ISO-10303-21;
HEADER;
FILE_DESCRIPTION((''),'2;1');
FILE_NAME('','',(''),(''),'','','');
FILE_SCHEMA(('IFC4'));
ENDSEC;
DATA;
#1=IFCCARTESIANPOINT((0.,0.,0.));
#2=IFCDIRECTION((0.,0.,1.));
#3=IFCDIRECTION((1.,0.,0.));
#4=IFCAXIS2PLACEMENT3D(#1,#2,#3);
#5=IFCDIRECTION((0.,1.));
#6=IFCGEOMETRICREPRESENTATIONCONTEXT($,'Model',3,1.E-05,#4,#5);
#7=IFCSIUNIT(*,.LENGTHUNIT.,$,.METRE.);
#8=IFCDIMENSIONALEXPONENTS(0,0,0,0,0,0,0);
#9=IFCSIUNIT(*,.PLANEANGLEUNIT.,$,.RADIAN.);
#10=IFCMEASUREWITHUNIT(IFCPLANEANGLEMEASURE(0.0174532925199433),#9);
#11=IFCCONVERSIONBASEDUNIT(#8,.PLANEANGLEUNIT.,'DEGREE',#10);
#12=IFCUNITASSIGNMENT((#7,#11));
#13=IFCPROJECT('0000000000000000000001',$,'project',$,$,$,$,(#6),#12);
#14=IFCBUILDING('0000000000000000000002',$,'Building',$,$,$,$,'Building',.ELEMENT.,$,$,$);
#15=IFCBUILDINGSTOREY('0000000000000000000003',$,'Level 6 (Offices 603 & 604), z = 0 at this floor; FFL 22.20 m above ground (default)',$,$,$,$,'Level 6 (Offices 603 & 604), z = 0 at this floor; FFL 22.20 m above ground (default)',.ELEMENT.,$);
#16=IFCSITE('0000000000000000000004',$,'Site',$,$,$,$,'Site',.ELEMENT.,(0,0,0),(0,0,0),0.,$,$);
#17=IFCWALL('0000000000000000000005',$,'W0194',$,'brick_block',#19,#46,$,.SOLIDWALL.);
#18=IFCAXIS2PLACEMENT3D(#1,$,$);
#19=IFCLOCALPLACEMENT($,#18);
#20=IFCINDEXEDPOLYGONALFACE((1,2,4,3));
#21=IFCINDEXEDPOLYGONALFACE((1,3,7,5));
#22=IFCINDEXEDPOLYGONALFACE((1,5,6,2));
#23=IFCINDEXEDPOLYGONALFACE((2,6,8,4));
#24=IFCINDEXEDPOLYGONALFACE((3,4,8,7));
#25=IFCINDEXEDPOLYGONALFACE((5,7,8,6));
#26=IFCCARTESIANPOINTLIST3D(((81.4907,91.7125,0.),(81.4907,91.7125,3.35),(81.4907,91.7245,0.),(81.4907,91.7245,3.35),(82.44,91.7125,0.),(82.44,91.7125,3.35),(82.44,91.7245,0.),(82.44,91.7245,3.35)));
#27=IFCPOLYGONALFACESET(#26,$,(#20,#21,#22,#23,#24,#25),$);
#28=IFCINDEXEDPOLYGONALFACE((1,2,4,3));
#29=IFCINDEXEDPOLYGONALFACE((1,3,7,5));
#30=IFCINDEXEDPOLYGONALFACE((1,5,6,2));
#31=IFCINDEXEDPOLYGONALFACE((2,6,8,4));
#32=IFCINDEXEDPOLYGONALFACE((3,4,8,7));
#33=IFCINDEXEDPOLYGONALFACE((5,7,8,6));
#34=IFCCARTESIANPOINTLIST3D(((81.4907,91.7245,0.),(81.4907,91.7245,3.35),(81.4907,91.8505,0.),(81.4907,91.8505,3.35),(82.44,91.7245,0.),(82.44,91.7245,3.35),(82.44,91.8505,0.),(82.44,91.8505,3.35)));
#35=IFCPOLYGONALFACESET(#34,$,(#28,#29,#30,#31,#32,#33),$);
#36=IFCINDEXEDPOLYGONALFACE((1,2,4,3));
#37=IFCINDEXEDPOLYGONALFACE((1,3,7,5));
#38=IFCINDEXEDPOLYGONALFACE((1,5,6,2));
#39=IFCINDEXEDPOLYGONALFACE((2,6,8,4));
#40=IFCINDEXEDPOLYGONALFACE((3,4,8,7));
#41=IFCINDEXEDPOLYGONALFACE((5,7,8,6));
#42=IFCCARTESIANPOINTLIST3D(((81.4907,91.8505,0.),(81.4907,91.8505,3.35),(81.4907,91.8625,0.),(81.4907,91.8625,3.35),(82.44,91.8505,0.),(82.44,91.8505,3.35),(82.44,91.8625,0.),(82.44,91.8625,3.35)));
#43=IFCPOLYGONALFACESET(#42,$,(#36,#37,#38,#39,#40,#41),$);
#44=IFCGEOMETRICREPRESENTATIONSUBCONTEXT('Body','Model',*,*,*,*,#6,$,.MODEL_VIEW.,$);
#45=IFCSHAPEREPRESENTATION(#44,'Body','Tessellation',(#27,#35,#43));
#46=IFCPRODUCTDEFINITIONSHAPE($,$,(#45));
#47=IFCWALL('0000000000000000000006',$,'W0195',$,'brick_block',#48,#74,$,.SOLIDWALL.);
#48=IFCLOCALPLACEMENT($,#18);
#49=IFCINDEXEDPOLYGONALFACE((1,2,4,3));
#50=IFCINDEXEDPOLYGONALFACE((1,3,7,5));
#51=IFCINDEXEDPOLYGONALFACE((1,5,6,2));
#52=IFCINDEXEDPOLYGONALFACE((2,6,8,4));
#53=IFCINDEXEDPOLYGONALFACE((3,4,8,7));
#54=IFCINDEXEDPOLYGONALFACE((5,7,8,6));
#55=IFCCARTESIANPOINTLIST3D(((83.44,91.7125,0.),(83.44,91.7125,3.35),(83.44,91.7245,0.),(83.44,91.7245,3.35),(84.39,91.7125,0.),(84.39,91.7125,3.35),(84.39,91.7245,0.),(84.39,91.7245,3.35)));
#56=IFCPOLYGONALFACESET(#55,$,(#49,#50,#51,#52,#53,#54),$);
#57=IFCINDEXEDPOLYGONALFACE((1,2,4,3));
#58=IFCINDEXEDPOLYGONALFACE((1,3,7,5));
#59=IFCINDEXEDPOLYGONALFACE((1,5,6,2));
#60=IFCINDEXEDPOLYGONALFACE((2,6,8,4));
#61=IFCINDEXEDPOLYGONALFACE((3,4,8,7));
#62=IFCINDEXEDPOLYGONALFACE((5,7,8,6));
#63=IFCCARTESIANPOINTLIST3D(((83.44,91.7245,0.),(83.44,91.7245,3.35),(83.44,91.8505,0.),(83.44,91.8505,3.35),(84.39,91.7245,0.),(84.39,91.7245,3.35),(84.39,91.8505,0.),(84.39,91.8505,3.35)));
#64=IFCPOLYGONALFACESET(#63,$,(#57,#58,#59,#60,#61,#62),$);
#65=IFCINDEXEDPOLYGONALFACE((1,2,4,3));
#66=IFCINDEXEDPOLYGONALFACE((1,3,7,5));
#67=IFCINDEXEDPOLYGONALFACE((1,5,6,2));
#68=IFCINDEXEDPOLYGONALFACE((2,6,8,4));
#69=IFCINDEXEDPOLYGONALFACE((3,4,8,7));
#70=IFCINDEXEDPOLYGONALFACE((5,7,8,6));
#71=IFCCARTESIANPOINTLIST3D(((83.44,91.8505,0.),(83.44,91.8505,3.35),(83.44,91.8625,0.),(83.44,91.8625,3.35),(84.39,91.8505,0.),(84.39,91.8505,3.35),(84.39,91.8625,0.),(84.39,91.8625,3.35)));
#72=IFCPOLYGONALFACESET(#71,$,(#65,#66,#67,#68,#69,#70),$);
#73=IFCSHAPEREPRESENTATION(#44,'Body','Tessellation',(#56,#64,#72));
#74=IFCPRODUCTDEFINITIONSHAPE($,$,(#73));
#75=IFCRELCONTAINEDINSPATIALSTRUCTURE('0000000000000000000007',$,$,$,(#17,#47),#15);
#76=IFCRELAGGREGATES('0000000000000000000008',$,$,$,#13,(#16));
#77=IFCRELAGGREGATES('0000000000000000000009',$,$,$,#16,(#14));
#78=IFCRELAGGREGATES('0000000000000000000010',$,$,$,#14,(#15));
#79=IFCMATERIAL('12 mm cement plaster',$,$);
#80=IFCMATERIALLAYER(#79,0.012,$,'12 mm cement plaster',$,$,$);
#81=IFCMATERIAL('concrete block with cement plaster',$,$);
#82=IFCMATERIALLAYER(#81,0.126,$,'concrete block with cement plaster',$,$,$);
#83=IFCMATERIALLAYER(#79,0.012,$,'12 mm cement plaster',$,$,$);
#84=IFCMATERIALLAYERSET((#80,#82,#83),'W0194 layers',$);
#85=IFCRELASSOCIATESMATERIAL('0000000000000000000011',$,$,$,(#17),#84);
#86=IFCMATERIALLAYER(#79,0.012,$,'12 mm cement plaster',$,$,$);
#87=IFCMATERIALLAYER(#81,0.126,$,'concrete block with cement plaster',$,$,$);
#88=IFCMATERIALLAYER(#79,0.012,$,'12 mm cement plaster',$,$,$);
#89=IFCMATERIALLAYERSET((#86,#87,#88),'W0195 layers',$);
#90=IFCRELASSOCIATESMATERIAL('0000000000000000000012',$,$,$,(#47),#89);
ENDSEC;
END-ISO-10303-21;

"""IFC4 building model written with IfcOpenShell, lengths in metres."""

from ifc_helpers import new_model, entity, si_unit, converted_unit, direction, frame, frame_2d, origin_with_axes, origin_2d_with_axis, place, context, subcontext, project, spatial, rectangle, extrude, material, layer, layer_set, layer_usage, element, save


model = new_model("IFC4")

# Units and contexts
model_context = context("Model", 3, precision=1e-05, world=origin_with_axes(), true_north=direction((0.0, 1.0)))
body_context = subcontext(model_context, "Body", "Model", "MODEL_VIEW")
ifc_project = project(units=[si_unit("LENGTHUNIT", "METRE"), converted_unit("PLANEANGLEUNIT", "DEGREE", entity("IfcPlaneAngleMeasure", 0.0174532925199433), si_unit("PLANEANGLEUNIT", "RADIAN"), dimensions=[0, 0, 0, 0, 0, 0, 0])], contexts=[model_context])

# Site, building, storey
site = spatial("IfcSite", under=ifc_project, Name="Site", LongName="Site", CompositionType="ELEMENT", RefLatitude=(0, 0, 0), RefLongitude=(0, 0, 0), RefElevation=0.0)
building = spatial("IfcBuilding", under=site, Name="Building", LongName="Building", CompositionType="ELEMENT")
storey = spatial("IfcBuildingStorey", under=building, Name="Level 6 (Offices 603 & 604), z = 0 at this floor; FFL 22.20 m above ground (default)", LongName="Level 6 (Offices 603 & 604), z = 0 at this floor; FFL 22.20 m above ground (default)", CompositionType="ELEMENT")

# Shared definitions
placement = place(None, origin_with_axes())

# Walls
ifc_material_1 = material(Name="12 mm cement plaster")
ifc_material_2 = material(Name="concrete block with cement plaster")
ifc_layer_1 = layer(ifc_material_1, 0.012, Name="12 mm cement plaster")
ifc_layer_2 = layer(ifc_material_2, 0.126, Name="concrete block with cement plaster")
ifc_layer_3 = layer(ifc_material_1, 0.012, Name="12 mm cement plaster")
ifc_layer_set_1 = layer_set([ifc_layer_1, ifc_layer_2, ifc_layer_3], Name="W0194 layers")
ifc_layer_usage_1 = layer_usage(ifc_layer_set_1, "AXIS2", "POSITIVE", -0.075)
element("IfcWall", 1, at=placement, inside=storey, material=ifc_layer_usage_1, Name="W0194", ObjectType="brick_block", PredefinedType="SOLIDWALL", context=body_context, shape_type="SweptSolid", body=[
    extrude(rectangle(XDim=0.9493, YDim=0.012, at=origin_2d_with_axis()), frame((81.9654, 91.7185, 0.0), z_axis=(0.0, 0.0, 1.0), x_axis=(1.0, 0.0, 0.0)), (0.0, 0.0, 1.0), 3.35),
    extrude(rectangle(XDim=0.9493, YDim=0.126, at=frame_2d((0.0, 0.069), x_axis=(1.0, 0.0))), frame((81.9654, 91.7185, 0.0), z_axis=(0.0, 0.0, 1.0), x_axis=(1.0, 0.0, 0.0)), (0.0, 0.0, 1.0), 3.35),
    extrude(rectangle(XDim=0.9493, YDim=0.012, at=frame_2d((0.0, 0.138), x_axis=(1.0, 0.0))), frame((81.9654, 91.7185, 0.0), z_axis=(0.0, 0.0, 1.0), x_axis=(1.0, 0.0, 0.0)), (0.0, 0.0, 1.0), 3.35),
])
ifc_layer_4 = layer(ifc_material_1, 0.012, Name="12 mm cement plaster")
ifc_layer_5 = layer(ifc_material_2, 0.126, Name="concrete block with cement plaster")
ifc_layer_6 = layer(ifc_material_1, 0.012, Name="12 mm cement plaster")
ifc_layer_set_2 = layer_set([ifc_layer_4, ifc_layer_5, ifc_layer_6], Name="W0195 layers")
ifc_layer_usage_2 = layer_usage(ifc_layer_set_2, "AXIS2", "POSITIVE", -0.075)
element("IfcWall", 2, at=placement, inside=storey, material=ifc_layer_usage_2, Name="W0195", ObjectType="brick_block", PredefinedType="SOLIDWALL", context=body_context, shape_type="SweptSolid", body=[
    extrude(rectangle(XDim=0.95, YDim=0.012, at=frame_2d((0.0, 0.0), x_axis=(1.0, 0.0))), frame((83.915, 91.7185, 0.0), z_axis=(0.0, 0.0, 1.0), x_axis=(1.0, 0.0, 0.0)), (0.0, 0.0, 1.0), 3.35),
    extrude(rectangle(XDim=0.95, YDim=0.126, at=frame_2d((0.0, 0.069), x_axis=(1.0, 0.0))), frame((83.915, 91.7185, 0.0), z_axis=(0.0, 0.0, 1.0), x_axis=(1.0, 0.0, 0.0)), (0.0, 0.0, 1.0), 3.35),
    extrude(rectangle(XDim=0.95, YDim=0.012, at=frame_2d((0.0, 0.138), x_axis=(1.0, 0.0))), frame((83.915, 91.7185, 0.0), z_axis=(0.0, 0.0, 1.0), x_axis=(1.0, 0.0, 0.0)), (0.0, 0.0, 1.0), 3.35),
])

save(model, "model.ifc")
